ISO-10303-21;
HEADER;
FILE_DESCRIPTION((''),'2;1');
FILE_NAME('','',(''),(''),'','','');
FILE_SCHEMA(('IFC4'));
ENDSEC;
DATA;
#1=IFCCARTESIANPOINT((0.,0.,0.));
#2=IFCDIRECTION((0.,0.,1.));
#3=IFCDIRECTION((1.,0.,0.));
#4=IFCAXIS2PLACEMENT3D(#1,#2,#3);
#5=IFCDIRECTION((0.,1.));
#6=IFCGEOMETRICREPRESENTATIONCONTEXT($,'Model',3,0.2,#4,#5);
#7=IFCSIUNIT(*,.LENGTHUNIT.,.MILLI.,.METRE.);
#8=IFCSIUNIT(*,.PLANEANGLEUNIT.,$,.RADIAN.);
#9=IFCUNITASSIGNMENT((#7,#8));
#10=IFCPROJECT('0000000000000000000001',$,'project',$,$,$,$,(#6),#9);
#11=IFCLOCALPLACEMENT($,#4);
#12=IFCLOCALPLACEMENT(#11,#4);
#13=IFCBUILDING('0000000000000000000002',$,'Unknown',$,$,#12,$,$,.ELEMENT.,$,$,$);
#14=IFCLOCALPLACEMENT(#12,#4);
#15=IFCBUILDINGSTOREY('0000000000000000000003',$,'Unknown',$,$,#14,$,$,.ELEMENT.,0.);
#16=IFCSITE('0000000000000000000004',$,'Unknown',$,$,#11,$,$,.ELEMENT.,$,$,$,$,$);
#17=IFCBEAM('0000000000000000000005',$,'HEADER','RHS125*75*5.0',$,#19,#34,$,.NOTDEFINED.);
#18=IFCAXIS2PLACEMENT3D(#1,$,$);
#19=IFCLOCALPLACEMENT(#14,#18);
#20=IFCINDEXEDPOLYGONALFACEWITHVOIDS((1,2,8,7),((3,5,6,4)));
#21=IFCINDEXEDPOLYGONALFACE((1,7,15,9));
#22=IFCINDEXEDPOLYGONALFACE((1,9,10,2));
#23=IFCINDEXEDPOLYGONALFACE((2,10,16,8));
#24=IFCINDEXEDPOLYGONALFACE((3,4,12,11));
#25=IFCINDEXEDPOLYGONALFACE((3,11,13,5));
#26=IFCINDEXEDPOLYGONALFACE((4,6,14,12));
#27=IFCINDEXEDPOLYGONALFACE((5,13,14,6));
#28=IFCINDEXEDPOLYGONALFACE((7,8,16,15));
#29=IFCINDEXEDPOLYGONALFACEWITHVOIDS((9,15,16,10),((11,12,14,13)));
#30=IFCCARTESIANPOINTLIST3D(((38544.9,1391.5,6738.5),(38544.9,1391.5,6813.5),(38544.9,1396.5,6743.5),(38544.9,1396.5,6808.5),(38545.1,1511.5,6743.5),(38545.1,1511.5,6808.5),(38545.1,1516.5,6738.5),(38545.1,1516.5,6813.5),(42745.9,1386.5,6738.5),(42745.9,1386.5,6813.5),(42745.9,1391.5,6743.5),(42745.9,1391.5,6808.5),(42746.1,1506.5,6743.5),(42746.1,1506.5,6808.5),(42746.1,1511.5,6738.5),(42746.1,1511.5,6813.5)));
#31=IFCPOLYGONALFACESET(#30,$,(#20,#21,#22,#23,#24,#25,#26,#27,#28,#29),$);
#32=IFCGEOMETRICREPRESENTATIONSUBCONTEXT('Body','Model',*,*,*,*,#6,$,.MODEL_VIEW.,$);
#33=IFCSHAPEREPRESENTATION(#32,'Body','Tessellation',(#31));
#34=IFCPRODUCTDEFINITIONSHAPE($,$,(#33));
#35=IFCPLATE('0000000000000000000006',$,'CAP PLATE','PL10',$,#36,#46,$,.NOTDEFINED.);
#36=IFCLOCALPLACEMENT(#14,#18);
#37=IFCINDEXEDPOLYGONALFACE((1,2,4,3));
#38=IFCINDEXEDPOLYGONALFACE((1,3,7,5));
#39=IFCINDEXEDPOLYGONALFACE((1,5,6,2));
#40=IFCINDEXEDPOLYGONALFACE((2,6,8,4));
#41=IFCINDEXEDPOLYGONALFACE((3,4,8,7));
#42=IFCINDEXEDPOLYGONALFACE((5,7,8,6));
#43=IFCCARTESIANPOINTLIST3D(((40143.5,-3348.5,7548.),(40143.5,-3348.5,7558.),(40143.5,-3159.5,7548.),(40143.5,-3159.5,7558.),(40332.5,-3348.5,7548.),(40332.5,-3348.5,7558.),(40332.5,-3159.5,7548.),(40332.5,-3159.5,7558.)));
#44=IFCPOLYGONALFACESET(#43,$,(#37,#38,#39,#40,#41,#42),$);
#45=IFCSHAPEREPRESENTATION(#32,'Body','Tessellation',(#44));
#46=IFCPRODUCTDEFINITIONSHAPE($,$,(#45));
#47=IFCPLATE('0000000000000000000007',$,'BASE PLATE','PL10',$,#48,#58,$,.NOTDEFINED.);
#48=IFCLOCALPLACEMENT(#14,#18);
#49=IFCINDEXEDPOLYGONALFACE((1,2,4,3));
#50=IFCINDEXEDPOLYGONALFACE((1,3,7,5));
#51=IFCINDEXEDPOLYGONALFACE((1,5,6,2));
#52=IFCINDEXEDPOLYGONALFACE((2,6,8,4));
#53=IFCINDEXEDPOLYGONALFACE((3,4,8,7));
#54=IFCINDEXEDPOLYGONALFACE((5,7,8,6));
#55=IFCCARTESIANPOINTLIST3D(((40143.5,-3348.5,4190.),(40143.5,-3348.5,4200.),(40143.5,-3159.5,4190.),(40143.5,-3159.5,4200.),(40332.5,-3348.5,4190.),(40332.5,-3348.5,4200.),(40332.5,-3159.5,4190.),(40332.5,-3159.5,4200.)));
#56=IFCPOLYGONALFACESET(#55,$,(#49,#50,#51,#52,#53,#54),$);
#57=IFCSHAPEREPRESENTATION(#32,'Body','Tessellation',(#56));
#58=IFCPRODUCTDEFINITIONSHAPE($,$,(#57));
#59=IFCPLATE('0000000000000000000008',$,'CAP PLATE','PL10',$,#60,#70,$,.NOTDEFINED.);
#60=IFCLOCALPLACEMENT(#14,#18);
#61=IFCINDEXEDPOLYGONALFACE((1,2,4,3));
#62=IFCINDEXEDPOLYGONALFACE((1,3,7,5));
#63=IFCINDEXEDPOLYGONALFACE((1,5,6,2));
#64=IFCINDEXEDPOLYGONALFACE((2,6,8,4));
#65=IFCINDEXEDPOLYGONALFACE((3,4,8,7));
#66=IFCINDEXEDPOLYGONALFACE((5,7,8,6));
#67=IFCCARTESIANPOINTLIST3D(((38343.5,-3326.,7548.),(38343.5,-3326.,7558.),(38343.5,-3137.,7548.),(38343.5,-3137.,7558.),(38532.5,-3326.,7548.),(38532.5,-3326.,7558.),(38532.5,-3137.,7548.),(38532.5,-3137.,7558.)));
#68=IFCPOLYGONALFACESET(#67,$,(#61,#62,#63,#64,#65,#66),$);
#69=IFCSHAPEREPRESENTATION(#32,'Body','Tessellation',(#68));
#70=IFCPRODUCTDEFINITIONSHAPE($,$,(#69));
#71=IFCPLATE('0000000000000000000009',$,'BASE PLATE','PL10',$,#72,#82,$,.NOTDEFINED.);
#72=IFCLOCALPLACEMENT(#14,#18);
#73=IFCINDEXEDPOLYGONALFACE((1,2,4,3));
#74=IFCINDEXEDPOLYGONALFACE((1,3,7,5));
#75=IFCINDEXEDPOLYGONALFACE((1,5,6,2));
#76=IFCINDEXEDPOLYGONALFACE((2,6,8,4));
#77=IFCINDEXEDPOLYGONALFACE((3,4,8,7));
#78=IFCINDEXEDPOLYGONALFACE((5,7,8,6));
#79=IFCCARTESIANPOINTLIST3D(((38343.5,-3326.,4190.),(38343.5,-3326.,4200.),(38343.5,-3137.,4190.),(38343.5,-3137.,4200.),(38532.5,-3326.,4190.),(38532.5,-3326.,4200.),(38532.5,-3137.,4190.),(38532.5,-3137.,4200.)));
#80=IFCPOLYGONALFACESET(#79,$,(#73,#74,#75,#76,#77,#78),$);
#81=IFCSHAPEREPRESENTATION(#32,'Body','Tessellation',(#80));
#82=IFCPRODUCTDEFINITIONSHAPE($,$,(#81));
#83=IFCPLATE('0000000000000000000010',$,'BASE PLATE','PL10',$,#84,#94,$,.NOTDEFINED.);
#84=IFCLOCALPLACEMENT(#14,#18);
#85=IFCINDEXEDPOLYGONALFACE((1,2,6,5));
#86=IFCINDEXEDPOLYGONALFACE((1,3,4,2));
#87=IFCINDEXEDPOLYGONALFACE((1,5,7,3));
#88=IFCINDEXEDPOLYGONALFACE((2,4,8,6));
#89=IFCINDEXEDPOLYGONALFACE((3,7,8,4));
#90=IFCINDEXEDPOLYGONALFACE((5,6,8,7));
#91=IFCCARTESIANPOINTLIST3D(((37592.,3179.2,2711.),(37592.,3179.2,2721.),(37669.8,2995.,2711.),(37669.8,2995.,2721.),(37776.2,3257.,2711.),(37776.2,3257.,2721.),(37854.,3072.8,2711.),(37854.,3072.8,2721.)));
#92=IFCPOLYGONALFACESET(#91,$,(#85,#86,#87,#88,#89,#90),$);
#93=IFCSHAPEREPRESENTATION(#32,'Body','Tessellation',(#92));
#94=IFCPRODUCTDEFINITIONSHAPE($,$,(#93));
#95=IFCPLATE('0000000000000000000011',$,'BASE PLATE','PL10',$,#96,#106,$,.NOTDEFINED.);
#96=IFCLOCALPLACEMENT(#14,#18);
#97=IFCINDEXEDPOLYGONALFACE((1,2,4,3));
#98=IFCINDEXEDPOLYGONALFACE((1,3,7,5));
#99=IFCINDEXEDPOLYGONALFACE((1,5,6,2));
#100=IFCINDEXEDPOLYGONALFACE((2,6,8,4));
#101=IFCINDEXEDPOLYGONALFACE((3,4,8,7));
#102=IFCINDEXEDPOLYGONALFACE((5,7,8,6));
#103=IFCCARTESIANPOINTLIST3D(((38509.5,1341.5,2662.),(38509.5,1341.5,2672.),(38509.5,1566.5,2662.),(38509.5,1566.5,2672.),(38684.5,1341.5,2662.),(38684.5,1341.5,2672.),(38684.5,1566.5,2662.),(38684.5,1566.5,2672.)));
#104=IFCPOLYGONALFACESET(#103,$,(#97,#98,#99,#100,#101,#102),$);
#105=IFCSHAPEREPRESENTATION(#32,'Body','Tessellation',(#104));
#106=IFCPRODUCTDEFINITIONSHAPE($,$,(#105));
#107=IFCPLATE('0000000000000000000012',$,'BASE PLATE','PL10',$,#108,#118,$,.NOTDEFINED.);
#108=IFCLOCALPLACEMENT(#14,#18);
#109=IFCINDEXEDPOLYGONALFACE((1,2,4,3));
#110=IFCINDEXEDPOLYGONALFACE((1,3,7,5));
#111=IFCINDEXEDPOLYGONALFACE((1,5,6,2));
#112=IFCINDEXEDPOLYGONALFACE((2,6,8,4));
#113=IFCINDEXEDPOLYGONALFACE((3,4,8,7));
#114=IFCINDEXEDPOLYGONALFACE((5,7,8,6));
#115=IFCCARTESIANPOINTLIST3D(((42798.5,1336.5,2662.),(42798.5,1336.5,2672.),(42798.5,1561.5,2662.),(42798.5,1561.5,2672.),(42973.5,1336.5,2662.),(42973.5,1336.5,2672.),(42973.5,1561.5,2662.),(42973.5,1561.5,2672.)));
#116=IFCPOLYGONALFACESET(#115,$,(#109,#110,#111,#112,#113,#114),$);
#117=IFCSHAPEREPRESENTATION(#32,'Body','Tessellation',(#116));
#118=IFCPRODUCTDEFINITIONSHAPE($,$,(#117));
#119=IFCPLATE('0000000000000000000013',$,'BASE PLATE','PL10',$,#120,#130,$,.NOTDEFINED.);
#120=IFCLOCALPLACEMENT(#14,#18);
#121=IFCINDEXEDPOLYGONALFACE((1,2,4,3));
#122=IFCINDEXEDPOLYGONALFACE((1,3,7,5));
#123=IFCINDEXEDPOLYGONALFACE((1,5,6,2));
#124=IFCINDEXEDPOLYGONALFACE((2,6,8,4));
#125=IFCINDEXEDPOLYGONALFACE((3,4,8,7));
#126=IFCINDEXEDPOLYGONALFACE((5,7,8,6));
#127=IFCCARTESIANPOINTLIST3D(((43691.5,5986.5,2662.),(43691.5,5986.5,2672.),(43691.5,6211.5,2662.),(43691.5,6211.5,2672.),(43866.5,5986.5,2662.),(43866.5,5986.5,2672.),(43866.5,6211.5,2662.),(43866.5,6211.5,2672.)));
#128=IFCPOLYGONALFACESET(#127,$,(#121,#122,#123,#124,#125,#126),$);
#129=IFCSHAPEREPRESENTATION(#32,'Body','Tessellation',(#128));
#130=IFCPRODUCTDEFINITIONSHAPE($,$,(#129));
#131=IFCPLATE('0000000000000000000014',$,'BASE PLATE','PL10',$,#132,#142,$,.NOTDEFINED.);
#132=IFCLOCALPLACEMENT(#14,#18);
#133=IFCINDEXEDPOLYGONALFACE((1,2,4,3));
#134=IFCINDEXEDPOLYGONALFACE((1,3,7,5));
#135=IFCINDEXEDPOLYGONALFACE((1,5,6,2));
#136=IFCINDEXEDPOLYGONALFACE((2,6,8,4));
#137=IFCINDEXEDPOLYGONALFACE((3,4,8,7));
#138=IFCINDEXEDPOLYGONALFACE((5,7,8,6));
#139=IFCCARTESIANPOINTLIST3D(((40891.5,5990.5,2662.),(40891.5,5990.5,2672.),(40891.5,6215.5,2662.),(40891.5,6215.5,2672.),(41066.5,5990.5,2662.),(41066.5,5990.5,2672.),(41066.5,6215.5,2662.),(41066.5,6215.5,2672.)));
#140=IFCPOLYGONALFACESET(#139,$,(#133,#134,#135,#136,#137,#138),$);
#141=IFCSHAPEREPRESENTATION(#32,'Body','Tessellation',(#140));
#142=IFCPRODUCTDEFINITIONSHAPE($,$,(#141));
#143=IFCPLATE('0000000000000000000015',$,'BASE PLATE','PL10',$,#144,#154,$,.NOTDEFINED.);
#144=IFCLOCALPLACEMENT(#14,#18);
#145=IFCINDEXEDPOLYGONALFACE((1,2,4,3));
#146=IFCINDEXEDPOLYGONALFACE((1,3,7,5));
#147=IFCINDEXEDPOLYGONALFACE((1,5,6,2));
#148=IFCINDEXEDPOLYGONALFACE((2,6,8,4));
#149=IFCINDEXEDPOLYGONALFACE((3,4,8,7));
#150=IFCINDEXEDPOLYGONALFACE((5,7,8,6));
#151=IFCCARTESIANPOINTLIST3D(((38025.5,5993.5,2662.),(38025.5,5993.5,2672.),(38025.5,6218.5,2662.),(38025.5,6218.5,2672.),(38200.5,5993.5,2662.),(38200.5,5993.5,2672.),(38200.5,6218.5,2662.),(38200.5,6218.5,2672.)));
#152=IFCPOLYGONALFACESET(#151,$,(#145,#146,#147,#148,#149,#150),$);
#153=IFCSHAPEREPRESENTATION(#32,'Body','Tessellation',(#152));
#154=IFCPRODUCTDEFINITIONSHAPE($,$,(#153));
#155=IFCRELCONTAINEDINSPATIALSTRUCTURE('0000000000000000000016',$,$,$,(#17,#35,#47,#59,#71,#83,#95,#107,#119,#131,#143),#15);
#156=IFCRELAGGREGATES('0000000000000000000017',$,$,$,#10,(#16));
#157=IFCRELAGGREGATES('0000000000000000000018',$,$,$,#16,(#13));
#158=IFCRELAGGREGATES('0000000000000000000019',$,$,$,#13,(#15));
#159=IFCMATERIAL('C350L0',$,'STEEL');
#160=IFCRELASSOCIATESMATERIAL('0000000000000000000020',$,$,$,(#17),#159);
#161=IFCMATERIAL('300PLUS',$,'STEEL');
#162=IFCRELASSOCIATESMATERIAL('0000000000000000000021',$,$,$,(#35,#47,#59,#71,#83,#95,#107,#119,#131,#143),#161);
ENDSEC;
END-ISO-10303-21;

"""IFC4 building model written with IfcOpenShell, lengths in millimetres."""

from ifc_helpers import new_model, si_unit, direction, frame, origin_with_axes, place, context, subcontext, project, spatial, line, indexed_curve, outline, extrude, material, element, save


model = new_model("IFC4")

# Units and contexts
model_context = context("Model", 3, precision=0.2, world=origin_with_axes(), true_north=direction((0.0, 1.0)))
body_context = subcontext(model_context, "Body", "Model", "MODEL_VIEW")
ifc_project = project(units=[si_unit("LENGTHUNIT", "METRE", prefix="MILLI"), si_unit("PLANEANGLEUNIT", "RADIAN")], contexts=[model_context])

# Site, building, storey
site_placement = place(None, origin_with_axes())
site = spatial("IfcSite", under=ifc_project, at=site_placement, Name="Unknown", CompositionType="ELEMENT")
building_placement = place(site_placement, origin_with_axes())
building = spatial("IfcBuilding", under=site, at=building_placement, Name="Unknown", CompositionType="ELEMENT")
storey_placement = place(building_placement, origin_with_axes())
storey = spatial("IfcBuildingStorey", under=building, at=storey_placement, Name="Unknown", CompositionType="ELEMENT", Elevation=0.0)

# Shared definitions
ifc_material_1 = material(Name="C350L0", Category="STEEL")

# Beam
ifc_material_2 = material(Name="300PLUS", Category="STEEL")
beam_1_placement = place(storey_placement, frame((42746.0, 1449.0, 6776.0), z_axis=(0.0, 0.0, 1.0), x_axis=(-0.999999, 0.00119, 0.0)))
element("IfcBeam", 1, at=beam_1_placement, inside=storey, material=ifc_material_1, Name="HEADER", Description="RHS125*75*5.0", PredefinedType="NOTDEFINED", context=body_context, shape_type="SolidModel", body=[
    extrude(outline(indexed_curve([(-37.5, -62.5), (37.5, -62.5), (37.5, 62.5), (-37.5, 62.5)], segments=[line(1, 2, 3, 4, 1)]), holes=[indexed_curve([(-32.5, -57.5), (-32.5, 57.5), (32.5, 57.5), (32.5, -57.5)], segments=[line(1, 2, 3, 4, 1)])]), frame((0.0, 0.0, 0.0), z_axis=(-1.0, 0.0, 0.0), x_axis=(0.0, 0.0, 1.0)), (0.0, 0.0, -1.0), 4201.0),
])

# Plates
for number, where, z_axis, x_axis, name in (
    (2, (40143.5, -3348.5, 7553.0), (0.0, 0.0, 1.0), (1.0, 0.0, 0.0), "CAP PLATE"),
    (3, (40143.5, -3348.5, 4195.0), (0.0, 0.0, 1.0), (1.0, 0.0, 0.0), "BASE PLATE"),
    (4, (38343.5, -3326.0, 7553.0), (0.0, 0.0, 1.0), (1.0, 0.0, 0.0), "CAP PLATE"),
    (5, (38343.5, -3326.0, 4195.0), (0.0, 0.0, 1.0), (1.0, 0.0, 0.0), "BASE PLATE"),
):
    element("IfcPlate", number, at=place(storey_placement, frame(where, z_axis=z_axis, x_axis=x_axis)), inside=storey, material=ifc_material_2, Name=name, Description="PL10", PredefinedType="NOTDEFINED", context=body_context, shape_type="SolidModel", body=[
        extrude(outline(indexed_curve([(0.0, 0.0), (189.0, 0.0), (189.0, 189.0), (0.0, 189.0)], segments=[line(1, 2, 3, 4, 1)])), frame((0.0, 0.0, 5.0), z_axis=(0.0, 0.0, 1.0), x_axis=(1.0, 0.0, 0.0)), (0.0, 0.0, -1.0), 10.0),
    ])
plate_placement = place(storey_placement, frame((37592.0, 3179.2, 2716.0), z_axis=(0.0, 0.0, 1.0), x_axis=(0.389085, -0.921202, 0.0)))
element("IfcPlate", 6, at=plate_placement, inside=storey, material=ifc_material_2, Name="BASE PLATE", Description="PL10", PredefinedType="NOTDEFINED", context=body_context, shape_type="SolidModel", body=[
    extrude(outline(indexed_curve([(0.0, 0.0), (200.0, 0.0), (200.0, 200.0), (0.0, 200.0)], segments=[line(1, 2, 3, 4, 1)])), frame((0.0, 0.0, 5.0), z_axis=(0.0, 0.0, 1.0), x_axis=(1.0, 0.0, 0.0)), (0.0, 0.0, -1.0), 10.0),
])
for number, where, z_axis, x_axis, name in (
    (7, (38684.5, 1341.5, 2667.0), (0.0, 0.0, 1.0), (0.0, 1.0, 0.0), "BASE PLATE"),
    (8, (42973.5, 1336.5, 2667.0), (0.0, 0.0, 1.0), (0.0, 1.0, 0.0), "BASE PLATE"),
    (9, (43866.5, 5986.5, 2667.0), (0.0, 0.0, 1.0), (0.0, 1.0, 0.0), "BASE PLATE"),
    (10, (41066.5, 5990.5, 2667.0), (0.0, 0.0, 1.0), (0.0, 1.0, 0.0), "BASE PLATE"),
    (11, (38200.5, 5993.5, 2667.0), (0.0, 0.0, 1.0), (0.0, 1.0, 0.0), "BASE PLATE"),
):
    element("IfcPlate", number, at=place(storey_placement, frame(where, z_axis=z_axis, x_axis=x_axis)), inside=storey, material=ifc_material_2, Name=name, Description="PL10", PredefinedType="NOTDEFINED", context=body_context, shape_type="SolidModel", body=[
        extrude(outline(indexed_curve([(0.0, 0.0), (225.0, 0.0), (225.0, 175.0), (0.0, 175.0)], segments=[line(1, 2, 3, 4, 1)])), frame((0.0, 0.0, 5.0), z_axis=(0.0, 0.0, 1.0), x_axis=(1.0, 0.0, 0.0)), (0.0, 0.0, -1.0), 10.0),
    ])

save(model, "model.ifc")
